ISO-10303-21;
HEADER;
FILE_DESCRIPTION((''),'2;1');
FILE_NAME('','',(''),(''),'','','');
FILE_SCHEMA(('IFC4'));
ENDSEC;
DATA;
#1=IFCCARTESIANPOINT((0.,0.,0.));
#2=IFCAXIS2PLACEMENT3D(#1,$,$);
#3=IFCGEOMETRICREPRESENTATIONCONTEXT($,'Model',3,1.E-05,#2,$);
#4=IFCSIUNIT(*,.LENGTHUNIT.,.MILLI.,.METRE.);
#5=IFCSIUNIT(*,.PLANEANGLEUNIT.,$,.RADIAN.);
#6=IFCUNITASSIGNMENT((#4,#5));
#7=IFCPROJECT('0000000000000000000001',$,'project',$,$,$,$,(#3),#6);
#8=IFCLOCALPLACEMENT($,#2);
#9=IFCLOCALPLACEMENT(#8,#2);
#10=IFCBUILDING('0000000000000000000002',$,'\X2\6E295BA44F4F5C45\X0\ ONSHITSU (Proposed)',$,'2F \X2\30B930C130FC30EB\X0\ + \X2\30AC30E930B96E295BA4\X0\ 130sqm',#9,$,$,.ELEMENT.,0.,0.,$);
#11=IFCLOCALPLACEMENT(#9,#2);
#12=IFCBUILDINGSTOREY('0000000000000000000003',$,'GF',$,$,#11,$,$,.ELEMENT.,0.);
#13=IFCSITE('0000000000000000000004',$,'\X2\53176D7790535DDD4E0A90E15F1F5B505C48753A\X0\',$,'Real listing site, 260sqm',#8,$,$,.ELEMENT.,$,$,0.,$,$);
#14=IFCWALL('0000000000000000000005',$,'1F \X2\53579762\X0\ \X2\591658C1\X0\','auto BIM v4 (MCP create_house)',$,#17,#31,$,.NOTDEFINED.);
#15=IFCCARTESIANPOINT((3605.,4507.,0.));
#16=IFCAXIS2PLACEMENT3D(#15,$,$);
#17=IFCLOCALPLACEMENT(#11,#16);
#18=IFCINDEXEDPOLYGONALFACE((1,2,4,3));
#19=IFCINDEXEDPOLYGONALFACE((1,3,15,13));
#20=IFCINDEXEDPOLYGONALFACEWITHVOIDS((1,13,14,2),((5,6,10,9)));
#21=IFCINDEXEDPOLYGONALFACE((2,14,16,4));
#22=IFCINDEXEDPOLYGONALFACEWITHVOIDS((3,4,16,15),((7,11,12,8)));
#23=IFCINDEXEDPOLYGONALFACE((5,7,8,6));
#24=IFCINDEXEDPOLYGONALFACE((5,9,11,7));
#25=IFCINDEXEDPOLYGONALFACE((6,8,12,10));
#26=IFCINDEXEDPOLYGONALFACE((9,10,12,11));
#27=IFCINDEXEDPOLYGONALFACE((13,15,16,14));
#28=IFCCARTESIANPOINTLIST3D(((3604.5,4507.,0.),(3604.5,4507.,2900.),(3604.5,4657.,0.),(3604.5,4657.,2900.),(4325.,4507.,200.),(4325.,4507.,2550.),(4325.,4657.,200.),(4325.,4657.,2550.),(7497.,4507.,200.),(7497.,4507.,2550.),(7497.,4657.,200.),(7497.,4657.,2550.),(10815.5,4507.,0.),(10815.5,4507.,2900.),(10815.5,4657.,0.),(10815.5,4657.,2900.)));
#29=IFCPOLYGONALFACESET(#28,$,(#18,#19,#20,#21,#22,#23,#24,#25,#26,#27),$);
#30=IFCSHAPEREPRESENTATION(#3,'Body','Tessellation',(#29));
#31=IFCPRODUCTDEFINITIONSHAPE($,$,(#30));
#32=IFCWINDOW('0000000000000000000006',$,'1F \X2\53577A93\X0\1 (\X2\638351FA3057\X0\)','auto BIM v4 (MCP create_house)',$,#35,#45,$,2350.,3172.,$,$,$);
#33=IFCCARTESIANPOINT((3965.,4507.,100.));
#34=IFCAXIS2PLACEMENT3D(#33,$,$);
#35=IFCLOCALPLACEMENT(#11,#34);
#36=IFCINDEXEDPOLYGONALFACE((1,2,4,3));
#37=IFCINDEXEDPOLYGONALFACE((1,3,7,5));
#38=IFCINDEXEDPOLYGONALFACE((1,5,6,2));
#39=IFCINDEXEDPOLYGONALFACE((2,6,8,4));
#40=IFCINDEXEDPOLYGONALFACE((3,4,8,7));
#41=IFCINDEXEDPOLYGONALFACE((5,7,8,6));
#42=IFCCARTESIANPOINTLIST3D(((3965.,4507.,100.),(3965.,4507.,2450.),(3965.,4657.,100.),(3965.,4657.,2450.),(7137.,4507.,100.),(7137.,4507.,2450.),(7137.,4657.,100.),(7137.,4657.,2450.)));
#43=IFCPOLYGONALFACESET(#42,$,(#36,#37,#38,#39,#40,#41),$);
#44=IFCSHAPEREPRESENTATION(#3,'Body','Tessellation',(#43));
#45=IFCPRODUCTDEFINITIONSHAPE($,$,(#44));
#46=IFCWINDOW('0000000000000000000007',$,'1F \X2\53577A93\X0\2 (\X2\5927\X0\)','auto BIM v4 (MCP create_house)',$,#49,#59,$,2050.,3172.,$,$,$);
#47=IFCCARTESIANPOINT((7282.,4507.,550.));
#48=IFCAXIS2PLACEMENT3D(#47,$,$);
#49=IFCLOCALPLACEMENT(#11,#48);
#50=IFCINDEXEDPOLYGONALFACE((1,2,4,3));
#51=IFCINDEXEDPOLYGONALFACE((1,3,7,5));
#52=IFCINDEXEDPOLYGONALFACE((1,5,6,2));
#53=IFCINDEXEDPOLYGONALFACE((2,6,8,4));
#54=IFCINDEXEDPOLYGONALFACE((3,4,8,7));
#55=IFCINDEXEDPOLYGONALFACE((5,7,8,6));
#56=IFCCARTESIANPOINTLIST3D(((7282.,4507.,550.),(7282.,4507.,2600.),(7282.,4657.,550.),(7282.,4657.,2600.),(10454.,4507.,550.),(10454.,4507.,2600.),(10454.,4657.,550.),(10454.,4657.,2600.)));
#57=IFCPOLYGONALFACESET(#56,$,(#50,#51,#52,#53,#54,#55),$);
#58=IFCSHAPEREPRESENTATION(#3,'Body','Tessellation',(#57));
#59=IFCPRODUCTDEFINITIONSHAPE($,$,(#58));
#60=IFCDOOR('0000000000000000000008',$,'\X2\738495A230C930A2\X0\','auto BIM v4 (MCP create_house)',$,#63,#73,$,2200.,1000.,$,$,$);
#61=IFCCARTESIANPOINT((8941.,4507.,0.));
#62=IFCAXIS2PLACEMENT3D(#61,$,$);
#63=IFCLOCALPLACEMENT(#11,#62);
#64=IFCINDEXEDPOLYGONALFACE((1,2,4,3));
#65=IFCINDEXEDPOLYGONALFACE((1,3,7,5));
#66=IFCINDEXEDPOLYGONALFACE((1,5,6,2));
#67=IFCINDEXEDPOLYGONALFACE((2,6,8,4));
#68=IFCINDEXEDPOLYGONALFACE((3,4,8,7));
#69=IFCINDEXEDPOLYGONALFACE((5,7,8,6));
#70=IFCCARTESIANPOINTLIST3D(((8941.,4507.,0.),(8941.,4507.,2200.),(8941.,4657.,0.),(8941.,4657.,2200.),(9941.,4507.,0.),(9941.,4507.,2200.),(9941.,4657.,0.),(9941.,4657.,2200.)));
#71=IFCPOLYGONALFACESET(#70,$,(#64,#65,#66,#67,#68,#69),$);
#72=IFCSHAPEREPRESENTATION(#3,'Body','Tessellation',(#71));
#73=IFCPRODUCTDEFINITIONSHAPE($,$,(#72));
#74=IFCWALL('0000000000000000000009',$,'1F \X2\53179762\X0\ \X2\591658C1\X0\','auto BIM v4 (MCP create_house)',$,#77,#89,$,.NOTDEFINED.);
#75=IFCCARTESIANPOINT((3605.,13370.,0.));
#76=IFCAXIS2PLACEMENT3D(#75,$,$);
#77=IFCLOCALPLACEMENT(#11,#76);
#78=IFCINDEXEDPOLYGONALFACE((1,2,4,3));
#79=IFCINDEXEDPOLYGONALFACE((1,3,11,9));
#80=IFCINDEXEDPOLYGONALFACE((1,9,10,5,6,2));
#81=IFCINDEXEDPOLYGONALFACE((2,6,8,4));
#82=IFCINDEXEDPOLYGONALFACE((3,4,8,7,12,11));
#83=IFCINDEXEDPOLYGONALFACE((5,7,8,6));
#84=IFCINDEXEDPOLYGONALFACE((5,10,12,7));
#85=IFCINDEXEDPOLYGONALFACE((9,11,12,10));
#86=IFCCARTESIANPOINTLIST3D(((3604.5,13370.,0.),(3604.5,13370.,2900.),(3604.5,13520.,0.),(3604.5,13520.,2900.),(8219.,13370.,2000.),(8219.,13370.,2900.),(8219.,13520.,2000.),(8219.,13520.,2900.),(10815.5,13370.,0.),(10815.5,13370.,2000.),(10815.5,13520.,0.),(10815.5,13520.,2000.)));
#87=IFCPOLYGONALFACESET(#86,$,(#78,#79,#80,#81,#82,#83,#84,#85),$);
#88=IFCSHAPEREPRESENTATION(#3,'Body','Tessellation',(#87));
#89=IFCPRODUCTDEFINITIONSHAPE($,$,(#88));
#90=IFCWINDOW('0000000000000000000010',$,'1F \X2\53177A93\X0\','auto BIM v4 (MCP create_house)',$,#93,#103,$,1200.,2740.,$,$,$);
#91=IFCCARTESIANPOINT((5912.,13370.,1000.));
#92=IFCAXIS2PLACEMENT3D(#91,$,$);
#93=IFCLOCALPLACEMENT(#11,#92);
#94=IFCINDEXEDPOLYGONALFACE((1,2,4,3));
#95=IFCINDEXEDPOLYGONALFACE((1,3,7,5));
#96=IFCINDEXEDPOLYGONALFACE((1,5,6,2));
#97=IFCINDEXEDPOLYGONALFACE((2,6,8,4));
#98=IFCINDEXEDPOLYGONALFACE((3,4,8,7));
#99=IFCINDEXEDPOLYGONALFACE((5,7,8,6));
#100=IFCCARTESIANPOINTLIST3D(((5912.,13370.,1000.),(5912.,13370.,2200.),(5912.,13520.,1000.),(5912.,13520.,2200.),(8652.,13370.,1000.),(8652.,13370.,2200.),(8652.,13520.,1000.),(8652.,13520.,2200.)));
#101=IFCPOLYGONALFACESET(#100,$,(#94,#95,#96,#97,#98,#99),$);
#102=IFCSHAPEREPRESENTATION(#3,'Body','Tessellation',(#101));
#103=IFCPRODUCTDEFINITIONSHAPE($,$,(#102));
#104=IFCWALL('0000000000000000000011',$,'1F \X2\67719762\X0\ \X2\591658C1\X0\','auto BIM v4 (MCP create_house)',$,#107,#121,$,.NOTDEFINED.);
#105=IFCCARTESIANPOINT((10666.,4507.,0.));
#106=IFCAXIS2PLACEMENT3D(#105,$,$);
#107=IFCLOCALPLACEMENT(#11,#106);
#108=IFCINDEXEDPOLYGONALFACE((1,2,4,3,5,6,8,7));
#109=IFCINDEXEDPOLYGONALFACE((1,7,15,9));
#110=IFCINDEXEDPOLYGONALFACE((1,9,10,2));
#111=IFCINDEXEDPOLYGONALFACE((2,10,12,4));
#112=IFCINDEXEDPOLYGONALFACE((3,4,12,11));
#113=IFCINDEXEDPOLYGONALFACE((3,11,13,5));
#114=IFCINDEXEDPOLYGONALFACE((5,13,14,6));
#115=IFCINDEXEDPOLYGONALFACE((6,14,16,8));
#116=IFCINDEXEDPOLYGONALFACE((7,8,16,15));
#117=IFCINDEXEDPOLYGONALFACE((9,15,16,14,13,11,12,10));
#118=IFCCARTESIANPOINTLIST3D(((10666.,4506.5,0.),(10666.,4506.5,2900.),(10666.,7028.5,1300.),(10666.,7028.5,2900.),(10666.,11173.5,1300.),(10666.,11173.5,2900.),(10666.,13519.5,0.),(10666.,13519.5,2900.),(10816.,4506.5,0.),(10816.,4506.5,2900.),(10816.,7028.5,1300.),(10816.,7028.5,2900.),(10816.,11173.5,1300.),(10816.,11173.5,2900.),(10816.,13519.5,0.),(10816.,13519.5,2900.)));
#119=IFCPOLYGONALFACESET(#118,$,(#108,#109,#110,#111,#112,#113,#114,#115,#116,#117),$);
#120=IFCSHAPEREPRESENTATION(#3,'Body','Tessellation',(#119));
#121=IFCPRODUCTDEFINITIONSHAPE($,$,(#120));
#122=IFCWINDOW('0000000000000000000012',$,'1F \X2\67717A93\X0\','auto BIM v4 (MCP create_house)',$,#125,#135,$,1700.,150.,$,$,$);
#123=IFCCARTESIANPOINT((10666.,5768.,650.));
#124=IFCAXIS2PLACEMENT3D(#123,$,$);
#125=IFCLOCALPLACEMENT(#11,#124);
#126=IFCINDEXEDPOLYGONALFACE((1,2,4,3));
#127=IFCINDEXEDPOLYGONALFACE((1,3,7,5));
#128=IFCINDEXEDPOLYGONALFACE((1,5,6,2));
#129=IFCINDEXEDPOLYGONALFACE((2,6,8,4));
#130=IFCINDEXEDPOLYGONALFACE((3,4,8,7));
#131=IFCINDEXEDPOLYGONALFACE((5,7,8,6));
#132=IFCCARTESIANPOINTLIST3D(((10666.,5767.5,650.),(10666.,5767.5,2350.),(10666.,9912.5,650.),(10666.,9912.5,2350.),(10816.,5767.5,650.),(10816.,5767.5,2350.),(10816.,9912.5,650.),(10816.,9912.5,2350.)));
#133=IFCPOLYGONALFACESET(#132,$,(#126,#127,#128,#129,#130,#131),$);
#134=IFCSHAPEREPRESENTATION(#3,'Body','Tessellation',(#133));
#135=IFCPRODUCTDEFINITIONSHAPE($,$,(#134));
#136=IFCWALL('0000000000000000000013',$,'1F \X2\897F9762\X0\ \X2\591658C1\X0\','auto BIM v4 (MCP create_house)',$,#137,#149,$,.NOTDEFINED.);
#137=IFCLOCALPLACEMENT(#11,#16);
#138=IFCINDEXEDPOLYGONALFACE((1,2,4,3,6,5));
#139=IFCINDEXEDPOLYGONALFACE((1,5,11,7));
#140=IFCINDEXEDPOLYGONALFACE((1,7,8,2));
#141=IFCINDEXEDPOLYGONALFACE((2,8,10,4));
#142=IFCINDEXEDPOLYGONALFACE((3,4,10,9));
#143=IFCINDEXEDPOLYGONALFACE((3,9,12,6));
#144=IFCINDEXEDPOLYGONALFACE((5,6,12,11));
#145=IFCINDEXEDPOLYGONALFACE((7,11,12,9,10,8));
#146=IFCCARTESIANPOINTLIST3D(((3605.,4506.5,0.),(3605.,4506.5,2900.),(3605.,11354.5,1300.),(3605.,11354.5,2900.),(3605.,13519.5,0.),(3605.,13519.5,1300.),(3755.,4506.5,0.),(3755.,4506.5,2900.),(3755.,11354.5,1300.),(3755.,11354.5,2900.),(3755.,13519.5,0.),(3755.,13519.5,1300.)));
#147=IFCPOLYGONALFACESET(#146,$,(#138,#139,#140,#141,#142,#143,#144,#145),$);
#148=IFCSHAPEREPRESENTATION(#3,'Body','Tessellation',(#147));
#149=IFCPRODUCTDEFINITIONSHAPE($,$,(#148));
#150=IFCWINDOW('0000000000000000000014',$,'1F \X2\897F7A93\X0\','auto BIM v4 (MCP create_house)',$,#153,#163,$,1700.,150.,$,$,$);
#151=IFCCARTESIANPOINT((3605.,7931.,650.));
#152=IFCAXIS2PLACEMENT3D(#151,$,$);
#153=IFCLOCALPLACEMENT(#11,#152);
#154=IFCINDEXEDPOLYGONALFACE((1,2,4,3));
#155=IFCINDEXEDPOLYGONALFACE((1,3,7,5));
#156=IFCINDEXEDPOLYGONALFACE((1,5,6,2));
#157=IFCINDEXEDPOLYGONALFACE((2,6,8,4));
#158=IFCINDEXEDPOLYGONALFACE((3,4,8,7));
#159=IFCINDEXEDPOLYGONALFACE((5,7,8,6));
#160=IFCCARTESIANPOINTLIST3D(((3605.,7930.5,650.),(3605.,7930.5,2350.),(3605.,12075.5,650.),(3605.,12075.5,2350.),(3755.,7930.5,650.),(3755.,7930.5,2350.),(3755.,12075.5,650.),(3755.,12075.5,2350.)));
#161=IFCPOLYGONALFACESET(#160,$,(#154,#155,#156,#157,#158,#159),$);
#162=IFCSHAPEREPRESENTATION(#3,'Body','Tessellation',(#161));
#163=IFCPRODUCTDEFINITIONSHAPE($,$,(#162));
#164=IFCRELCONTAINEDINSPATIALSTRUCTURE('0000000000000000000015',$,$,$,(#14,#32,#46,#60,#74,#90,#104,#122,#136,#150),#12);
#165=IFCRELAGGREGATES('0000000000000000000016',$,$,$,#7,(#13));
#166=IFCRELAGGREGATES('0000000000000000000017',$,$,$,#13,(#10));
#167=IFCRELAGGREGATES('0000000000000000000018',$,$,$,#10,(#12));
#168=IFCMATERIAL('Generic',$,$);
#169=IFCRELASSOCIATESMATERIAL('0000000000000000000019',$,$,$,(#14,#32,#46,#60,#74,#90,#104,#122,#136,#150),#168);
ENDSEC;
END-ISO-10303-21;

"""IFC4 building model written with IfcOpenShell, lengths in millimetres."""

from ifc_helpers import new_model, si_unit, frame, frame_2d, origin, place, context, project, spatial, rectangle, extrude, material, element, fill, save


model = new_model("IFC4")

# Units and contexts
model_context = context("Model", 3, precision=1e-05, world=origin())
ifc_project = project(units=[si_unit("LENGTHUNIT", "METRE", prefix="MILLI"), si_unit("PLANEANGLEUNIT", "RADIAN")], contexts=[model_context])

# Site, building, storey
site_placement = place(None, origin())
site = spatial("IfcSite", under=ifc_project, at=site_placement, Name="北海道川上郡弟子屈町", ObjectType="Real listing site, 260sqm", CompositionType="ELEMENT", RefElevation=0.0)
building_placement = place(site_placement, origin())
building = spatial("IfcBuilding", under=site, at=building_placement, Name="温室住居 ONSHITSU (Proposed)", ObjectType="2F スチール + ガラス温室 130sqm", CompositionType="ELEMENT", ElevationOfRefHeight=0.0, ElevationOfTerrain=0.0)
storey_placement = place(building_placement, origin())
storey = spatial("IfcBuildingStorey", under=building, at=storey_placement, Name="GF", CompositionType="ELEMENT", Elevation=0.0)

# Shared definitions
ifc_material = material(Name="Generic")

# Wall, openings, windows, door
wall_1_placement = place(storey_placement, frame((3605.0, 4507.0, 0.0)))
wall_1 = element("IfcWall", 1, at=wall_1_placement, inside=storey, material=ifc_material, Name="1F 南面 外壁", Description="auto BIM v4 (MCP create_house)", PredefinedType="NOTDEFINED", context=model_context, shape_type="SweptSolid", body=[
    extrude(rectangle(XDim=7211.0, YDim=150.0, at=frame_2d((3605.0, 75.0))), frame((3605.0, 4507.0, 0.0)), (0.0, 0.0, 1.0), 2900.0),
])
opening_1_placement = place(storey_placement, frame((3965.0, 4507.0, 100.0)))
opening_1 = element("IfcOpeningElement", 2, at=opening_1_placement, cuts=wall_1, PredefinedType="NOTDEFINED", context=model_context, shape_type="SweptSolid", body=[
    extrude(rectangle(XDim=3172.0, YDim=150.0, at=frame_2d((1586.0, 75.0))), frame((3965.0, 4507.0, 100.0)), (0.0, 0.0, 1.0), 2350.0),
])
opening_2_placement = place(storey_placement, frame((7282.0, 4507.0, 550.0)))
opening_2 = element("IfcOpeningElement", 3, at=opening_2_placement, cuts=wall_1, PredefinedType="NOTDEFINED", context=model_context, shape_type="SweptSolid", body=[
    extrude(rectangle(XDim=3172.0, YDim=150.0, at=frame_2d((1586.0, 75.0))), frame((7282.0, 4507.0, 550.0)), (0.0, 0.0, 1.0), 2050.0),
])
opening_3_placement = place(storey_placement, frame((8941.0, 4507.0, 0.0)))
opening_3 = element("IfcOpeningElement", 4, at=opening_3_placement, cuts=wall_1, PredefinedType="NOTDEFINED", context=model_context, shape_type="SweptSolid", body=[
    extrude(rectangle(XDim=1000.0, YDim=150.0, at=frame_2d((500.0, 75.0))), frame((8941.0, 4507.0, 0.0)), (0.0, 0.0, 1.0), 2200.0),
])
window_1_placement = place(storey_placement, frame((3965.0, 4507.0, 100.0)))
window_1 = element("IfcWindow", 5, at=window_1_placement, inside=storey, material=ifc_material, Name="1F 南窓1 (掃出し)", Description="auto BIM v4 (MCP create_house)", OverallHeight=2350.0, OverallWidth=3172.0, context=model_context, shape_type="SweptSolid", body=[
    extrude(rectangle(XDim=3172.0, YDim=150.0, at=frame_2d((1586.0, 75.0))), frame((3965.0, 4507.0, 100.0)), (0.0, 0.0, 1.0), 2350.0),
])
fill(opening_1, window_1)
window_2_placement = place(storey_placement, frame((7282.0, 4507.0, 550.0)))
window_2 = element("IfcWindow", 6, at=window_2_placement, inside=storey, material=ifc_material, Name="1F 南窓2 (大)", Description="auto BIM v4 (MCP create_house)", OverallHeight=2050.0, OverallWidth=3172.0, context=model_context, shape_type="SweptSolid", body=[
    extrude(rectangle(XDim=3172.0, YDim=150.0, at=frame_2d((1586.0, 75.0))), frame((7282.0, 4507.0, 550.0)), (0.0, 0.0, 1.0), 2050.0),
])
fill(opening_2, window_2)
door_1_placement = place(storey_placement, frame((8941.0, 4507.0, 0.0)))
door_1 = element("IfcDoor", 7, at=door_1_placement, inside=storey, material=ifc_material, Name="玄関ドア", Description="auto BIM v4 (MCP create_house)", OverallHeight=2200.0, OverallWidth=1000.0, context=model_context, shape_type="SweptSolid", body=[
    extrude(rectangle(XDim=1000.0, YDim=150.0, at=frame_2d((500.0, 75.0))), frame((8941.0, 4507.0, 0.0)), (0.0, 0.0, 1.0), 2200.0),
])
fill(opening_3, door_1)

# Walls, openings, windows
wall_2_placement = place(storey_placement, frame((3605.0, 13370.0, 0.0)))
wall_2 = element("IfcWall", 8, at=wall_2_placement, inside=storey, material=ifc_material, Name="1F 北面 外壁", Description="auto BIM v4 (MCP create_house)", PredefinedType="NOTDEFINED", context=model_context, shape_type="SweptSolid", body=[
    extrude(rectangle(XDim=7211.0, YDim=150.0, at=frame_2d((3605.0, 75.0))), frame((3605.0, 13370.0, 0.0)), (0.0, 0.0, 1.0), 2900.0),
])
opening_4_placement = place(storey_placement, frame((5912.0, 13370.0, 1000.0)))
opening_4 = element("IfcOpeningElement", 9, at=opening_4_placement, cuts=wall_2, PredefinedType="NOTDEFINED", context=model_context, shape_type="SweptSolid", body=[
    extrude(rectangle(XDim=2740.0, YDim=150.0, at=frame_2d((1370.0, 75.0))), frame((5912.0, 13370.0, 1000.0)), (0.0, 0.0, 1.0), 1200.0),
])
window_3_placement = place(storey_placement, frame((5912.0, 13370.0, 1000.0)))
window_3 = element("IfcWindow", 10, at=window_3_placement, inside=storey, material=ifc_material, Name="1F 北窓", Description="auto BIM v4 (MCP create_house)", OverallHeight=1200.0, OverallWidth=2740.0, context=model_context, shape_type="SweptSolid", body=[
    extrude(rectangle(XDim=2740.0, YDim=150.0, at=frame_2d((1370.0, 75.0))), frame((5912.0, 13370.0, 1000.0)), (0.0, 0.0, 1.0), 1200.0),
])
fill(opening_4, window_3)
wall_3_placement = place(storey_placement, frame((10666.0, 4507.0, 0.0)))
wall_3 = element("IfcWall", 11, at=wall_3_placement, inside=storey, material=ifc_material, Name="1F 東面 外壁", Description="auto BIM v4 (MCP create_house)", PredefinedType="NOTDEFINED", context=model_context, shape_type="SweptSolid", body=[
    extrude(rectangle(XDim=150.0, YDim=9013.0, at=frame_2d((75.0, 4506.0))), frame((10666.0, 4507.0, 0.0)), (0.0, 0.0, 1.0), 2900.0),
])
opening_5_placement = place(storey_placement, frame((10666.0, 5768.0, 650.0)))
opening_5 = element("IfcOpeningElement", 12, at=opening_5_placement, cuts=wall_3, PredefinedType="NOTDEFINED", context=model_context, shape_type="SweptSolid", body=[
    extrude(rectangle(XDim=150.0, YDim=4145.0, at=frame_2d((75.0, 2072.0))), frame((10666.0, 5768.0, 650.0)), (0.0, 0.0, 1.0), 1700.0),
])
window_4_placement = place(storey_placement, frame((10666.0, 5768.0, 650.0)))
window_4 = element("IfcWindow", 13, at=window_4_placement, inside=storey, material=ifc_material, Name="1F 東窓", Description="auto BIM v4 (MCP create_house)", OverallHeight=1700.0, OverallWidth=150.0, context=model_context, shape_type="SweptSolid", body=[
    extrude(rectangle(XDim=150.0, YDim=4145.0, at=frame_2d((75.0, 2072.0))), frame((10666.0, 5768.0, 650.0)), (0.0, 0.0, 1.0), 1700.0),
])
fill(opening_5, window_4)
wall_4_placement = place(storey_placement, frame((3605.0, 4507.0, 0.0)))
wall_4 = element("IfcWall", 14, at=wall_4_placement, inside=storey, material=ifc_material, Name="1F 西面 外壁", Description="auto BIM v4 (MCP create_house)", PredefinedType="NOTDEFINED", context=model_context, shape_type="SweptSolid", body=[
    extrude(rectangle(XDim=150.0, YDim=9013.0, at=frame_2d((75.0, 4506.0))), frame((3605.0, 4507.0, 0.0)), (0.0, 0.0, 1.0), 2900.0),
])
opening_6_placement = place(storey_placement, frame((3605.0, 7931.0, 650.0)))
opening_6 = element("IfcOpeningElement", 15, at=opening_6_placement, cuts=wall_4, PredefinedType="NOTDEFINED", context=model_context, shape_type="SweptSolid", body=[
    extrude(rectangle(XDim=150.0, YDim=4145.0, at=frame_2d((75.0, 2072.0))), frame((3605.0, 7931.0, 650.0)), (0.0, 0.0, 1.0), 1700.0),
])
window_5_placement = place(storey_placement, frame((3605.0, 7931.0, 650.0)))
window_5 = element("IfcWindow", 16, at=window_5_placement, inside=storey, material=ifc_material, Name="1F 西窓", Description="auto BIM v4 (MCP create_house)", OverallHeight=1700.0, OverallWidth=150.0, context=model_context, shape_type="SweptSolid", body=[
    extrude(rectangle(XDim=150.0, YDim=4145.0, at=frame_2d((75.0, 2072.0))), frame((3605.0, 7931.0, 650.0)), (0.0, 0.0, 1.0), 1700.0),
])
fill(opening_6, window_5)

save(model, "model.ifc")
